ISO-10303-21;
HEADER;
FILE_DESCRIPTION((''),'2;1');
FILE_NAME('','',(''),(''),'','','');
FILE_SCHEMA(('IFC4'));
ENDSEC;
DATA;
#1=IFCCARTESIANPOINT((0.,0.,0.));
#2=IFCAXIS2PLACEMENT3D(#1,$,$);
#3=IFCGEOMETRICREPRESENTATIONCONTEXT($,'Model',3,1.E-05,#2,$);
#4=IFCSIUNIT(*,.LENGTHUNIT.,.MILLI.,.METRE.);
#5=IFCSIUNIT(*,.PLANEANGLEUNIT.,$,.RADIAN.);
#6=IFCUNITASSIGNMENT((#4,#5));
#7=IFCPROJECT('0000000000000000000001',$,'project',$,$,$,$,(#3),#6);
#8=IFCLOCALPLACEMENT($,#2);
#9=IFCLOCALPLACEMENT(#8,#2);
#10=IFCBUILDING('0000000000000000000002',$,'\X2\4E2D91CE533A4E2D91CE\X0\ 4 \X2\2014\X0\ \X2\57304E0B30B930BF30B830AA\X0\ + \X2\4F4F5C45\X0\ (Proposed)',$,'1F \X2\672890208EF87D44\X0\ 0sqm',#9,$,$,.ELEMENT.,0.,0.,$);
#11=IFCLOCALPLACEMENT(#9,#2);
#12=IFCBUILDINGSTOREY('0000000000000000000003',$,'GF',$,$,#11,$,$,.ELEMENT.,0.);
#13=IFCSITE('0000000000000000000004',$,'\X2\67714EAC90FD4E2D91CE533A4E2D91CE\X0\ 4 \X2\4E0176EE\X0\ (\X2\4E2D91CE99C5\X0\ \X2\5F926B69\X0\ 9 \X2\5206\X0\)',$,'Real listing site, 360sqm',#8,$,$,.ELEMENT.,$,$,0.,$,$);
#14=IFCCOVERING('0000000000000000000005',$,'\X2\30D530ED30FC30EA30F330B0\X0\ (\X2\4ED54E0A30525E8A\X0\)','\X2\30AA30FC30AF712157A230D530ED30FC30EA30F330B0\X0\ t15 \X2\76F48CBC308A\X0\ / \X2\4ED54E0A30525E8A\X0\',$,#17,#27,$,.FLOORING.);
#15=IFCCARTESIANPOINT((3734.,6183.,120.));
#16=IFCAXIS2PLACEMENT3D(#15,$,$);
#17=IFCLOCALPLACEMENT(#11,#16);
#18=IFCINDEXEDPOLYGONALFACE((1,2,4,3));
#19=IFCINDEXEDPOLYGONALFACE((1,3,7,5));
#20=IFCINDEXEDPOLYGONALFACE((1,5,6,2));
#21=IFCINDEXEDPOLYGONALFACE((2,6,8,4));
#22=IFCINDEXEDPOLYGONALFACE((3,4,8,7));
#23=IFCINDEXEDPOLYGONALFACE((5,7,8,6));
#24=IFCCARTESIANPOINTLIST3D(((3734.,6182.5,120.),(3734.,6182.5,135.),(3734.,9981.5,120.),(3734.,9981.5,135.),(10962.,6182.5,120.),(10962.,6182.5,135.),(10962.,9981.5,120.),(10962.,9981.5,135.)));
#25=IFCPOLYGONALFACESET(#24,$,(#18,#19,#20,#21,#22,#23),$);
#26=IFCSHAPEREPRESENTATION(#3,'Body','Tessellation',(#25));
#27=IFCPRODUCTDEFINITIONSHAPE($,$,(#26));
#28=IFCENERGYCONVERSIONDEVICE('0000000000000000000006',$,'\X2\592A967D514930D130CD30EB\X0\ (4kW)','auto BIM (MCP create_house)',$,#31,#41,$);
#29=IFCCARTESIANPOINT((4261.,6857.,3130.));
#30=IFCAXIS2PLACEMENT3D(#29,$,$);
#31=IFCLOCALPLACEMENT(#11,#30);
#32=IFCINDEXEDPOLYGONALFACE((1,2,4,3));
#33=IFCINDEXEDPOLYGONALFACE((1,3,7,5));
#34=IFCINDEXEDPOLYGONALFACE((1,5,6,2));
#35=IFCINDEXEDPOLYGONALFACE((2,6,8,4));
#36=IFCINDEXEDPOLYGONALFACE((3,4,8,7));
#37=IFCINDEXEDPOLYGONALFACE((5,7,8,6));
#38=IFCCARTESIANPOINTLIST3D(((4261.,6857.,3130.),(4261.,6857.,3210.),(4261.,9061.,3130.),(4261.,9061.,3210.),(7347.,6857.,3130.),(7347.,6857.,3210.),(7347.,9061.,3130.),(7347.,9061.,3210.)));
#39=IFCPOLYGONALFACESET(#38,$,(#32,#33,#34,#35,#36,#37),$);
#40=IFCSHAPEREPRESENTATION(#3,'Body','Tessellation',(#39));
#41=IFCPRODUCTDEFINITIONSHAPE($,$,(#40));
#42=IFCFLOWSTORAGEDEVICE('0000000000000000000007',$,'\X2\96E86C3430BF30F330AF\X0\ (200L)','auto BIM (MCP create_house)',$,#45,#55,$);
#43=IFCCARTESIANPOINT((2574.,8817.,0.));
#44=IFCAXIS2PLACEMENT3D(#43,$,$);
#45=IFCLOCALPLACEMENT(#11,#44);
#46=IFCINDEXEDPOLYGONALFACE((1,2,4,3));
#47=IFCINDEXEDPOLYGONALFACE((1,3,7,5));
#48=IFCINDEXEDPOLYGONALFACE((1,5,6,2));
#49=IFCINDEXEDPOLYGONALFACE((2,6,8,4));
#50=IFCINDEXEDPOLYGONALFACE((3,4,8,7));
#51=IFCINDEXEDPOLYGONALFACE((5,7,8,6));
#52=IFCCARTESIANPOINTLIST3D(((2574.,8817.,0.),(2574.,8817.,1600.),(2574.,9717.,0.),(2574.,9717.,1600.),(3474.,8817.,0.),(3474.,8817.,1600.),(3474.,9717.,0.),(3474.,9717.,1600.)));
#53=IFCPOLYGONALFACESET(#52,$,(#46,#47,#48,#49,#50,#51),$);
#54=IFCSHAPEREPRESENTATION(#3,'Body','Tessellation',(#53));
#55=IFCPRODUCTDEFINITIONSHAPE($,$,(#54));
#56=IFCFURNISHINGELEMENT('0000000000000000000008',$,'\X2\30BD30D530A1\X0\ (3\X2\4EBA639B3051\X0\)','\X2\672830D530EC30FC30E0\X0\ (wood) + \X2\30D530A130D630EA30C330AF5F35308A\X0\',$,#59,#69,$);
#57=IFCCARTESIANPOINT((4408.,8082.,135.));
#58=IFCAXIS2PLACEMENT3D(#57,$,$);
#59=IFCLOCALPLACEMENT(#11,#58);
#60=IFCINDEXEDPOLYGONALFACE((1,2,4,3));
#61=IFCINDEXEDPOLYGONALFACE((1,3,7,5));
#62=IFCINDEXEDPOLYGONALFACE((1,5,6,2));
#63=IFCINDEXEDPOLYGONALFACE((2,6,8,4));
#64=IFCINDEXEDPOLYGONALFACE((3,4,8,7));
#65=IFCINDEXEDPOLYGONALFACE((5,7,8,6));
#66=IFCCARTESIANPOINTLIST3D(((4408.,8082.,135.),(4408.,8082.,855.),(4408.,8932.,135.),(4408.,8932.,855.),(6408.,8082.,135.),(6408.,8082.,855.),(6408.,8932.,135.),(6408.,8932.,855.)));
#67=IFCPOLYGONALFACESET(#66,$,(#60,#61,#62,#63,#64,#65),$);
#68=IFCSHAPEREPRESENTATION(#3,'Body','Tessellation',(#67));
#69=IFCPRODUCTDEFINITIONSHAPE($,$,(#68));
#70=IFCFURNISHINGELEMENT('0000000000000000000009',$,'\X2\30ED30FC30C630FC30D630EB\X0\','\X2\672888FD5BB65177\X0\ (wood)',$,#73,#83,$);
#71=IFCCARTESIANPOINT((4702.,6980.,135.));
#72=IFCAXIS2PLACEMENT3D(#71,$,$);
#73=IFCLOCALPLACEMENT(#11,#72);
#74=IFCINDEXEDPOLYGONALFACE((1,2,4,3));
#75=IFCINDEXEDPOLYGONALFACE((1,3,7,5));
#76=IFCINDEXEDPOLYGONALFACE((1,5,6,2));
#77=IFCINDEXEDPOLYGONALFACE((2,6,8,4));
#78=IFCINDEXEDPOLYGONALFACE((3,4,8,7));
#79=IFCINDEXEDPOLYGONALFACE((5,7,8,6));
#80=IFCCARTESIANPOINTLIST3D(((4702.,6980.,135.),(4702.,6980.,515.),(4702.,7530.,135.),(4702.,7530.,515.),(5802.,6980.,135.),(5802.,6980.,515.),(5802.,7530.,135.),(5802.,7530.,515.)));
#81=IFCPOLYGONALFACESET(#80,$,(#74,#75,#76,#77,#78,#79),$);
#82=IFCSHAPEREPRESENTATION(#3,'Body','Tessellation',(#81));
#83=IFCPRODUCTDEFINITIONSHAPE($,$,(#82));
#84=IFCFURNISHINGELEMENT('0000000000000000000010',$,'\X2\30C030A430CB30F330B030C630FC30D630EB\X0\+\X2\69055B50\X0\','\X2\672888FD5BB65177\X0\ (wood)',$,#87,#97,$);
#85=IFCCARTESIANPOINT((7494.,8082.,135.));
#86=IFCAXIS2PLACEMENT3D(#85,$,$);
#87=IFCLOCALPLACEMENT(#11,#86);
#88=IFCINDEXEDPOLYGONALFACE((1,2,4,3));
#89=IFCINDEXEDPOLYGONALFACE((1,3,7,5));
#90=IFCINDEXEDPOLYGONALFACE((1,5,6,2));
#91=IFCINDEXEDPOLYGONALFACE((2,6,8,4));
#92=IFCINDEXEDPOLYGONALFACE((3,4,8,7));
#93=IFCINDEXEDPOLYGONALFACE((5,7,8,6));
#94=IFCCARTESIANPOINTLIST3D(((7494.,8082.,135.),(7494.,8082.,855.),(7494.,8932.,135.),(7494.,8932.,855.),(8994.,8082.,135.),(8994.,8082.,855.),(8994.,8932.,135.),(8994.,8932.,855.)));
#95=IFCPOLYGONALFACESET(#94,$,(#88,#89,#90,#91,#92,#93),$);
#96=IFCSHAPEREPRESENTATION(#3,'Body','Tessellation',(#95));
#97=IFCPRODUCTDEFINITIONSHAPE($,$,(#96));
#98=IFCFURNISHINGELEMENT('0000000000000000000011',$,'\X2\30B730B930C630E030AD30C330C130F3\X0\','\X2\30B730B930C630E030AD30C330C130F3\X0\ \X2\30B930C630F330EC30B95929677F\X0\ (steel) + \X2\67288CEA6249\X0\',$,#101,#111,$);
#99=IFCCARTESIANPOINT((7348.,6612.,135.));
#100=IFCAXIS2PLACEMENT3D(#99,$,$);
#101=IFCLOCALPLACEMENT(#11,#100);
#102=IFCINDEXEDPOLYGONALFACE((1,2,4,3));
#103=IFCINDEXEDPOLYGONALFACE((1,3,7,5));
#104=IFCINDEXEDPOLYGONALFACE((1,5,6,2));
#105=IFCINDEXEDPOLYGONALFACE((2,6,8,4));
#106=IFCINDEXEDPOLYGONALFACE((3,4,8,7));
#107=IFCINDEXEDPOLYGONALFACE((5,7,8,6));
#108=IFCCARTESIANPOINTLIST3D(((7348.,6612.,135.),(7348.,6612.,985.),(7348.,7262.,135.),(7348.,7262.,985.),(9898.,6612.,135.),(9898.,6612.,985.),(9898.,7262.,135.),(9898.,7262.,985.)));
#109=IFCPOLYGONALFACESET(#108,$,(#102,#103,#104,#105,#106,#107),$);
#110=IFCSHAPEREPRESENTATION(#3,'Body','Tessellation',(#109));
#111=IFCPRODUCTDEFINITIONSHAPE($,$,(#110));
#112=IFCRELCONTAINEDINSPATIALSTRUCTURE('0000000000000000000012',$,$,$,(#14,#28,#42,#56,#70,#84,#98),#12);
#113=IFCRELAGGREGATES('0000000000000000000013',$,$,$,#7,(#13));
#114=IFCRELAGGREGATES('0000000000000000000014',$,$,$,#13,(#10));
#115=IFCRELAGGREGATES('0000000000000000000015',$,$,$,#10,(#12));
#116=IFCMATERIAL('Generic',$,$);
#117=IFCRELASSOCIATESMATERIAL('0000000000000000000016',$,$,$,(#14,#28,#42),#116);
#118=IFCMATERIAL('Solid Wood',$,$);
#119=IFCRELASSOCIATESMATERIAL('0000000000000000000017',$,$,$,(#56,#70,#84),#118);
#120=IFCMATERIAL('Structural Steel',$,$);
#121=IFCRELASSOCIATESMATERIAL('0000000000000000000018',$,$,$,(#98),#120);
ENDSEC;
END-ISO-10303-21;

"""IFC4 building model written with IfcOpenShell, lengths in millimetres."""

from ifc_helpers import new_model, si_unit, frame, frame_2d, origin, place, context, project, spatial, rectangle, extrude, material, element, save


model = new_model("IFC4")

# Units and contexts
model_context = context("Model", 3, precision=1e-05, world=origin())
ifc_project = project(units=[si_unit("LENGTHUNIT", "METRE", prefix="MILLI"), si_unit("PLANEANGLEUNIT", "RADIAN")], contexts=[model_context])

# Site, building, storey
site_placement = place(None, origin())
site = spatial("IfcSite", under=ifc_project, at=site_placement, Name="東京都中野区中野 4 丁目 (中野駅 徒歩 9 分)", ObjectType="Real listing site, 360sqm", CompositionType="ELEMENT", RefElevation=0.0)
building_placement = place(site_placement, origin())
building = spatial("IfcBuilding", under=site, at=building_placement, Name="中野区中野 4 — 地下スタジオ + 住居 (Proposed)", ObjectType="1F 木造軸組 0sqm", CompositionType="ELEMENT", ElevationOfRefHeight=0.0, ElevationOfTerrain=0.0)
storey_placement = place(building_placement, origin())
storey = spatial("IfcBuildingStorey", under=building, at=storey_placement, Name="GF", CompositionType="ELEMENT", Elevation=0.0)

# Shared definitions
ifc_material_1 = material(Name="Solid Wood")

# Shared definitions
ifc_material_2 = material(Name="Structural Steel")

# Covering
ifc_material_3 = material(Name="Generic")
covering_placement = place(storey_placement, frame((3734.0, 6183.0, 120.0)))
element("IfcCovering", 1, at=covering_placement, inside=storey, material=ifc_material_3, Name="フローリング (仕上げ床)", Description="オーク無垢フローリング t15 直貼り / 仕上げ床", PredefinedType="FLOORING", context=model_context, shape_type="SweptSolid", body=[
    extrude(rectangle(XDim=7228.0, YDim=3799.0, at=frame_2d((3614.0, 1899.0))), frame((3734.0, 6183.0, 120.0)), (0.0, 0.0, 1.0), 15.0),
])

# Energy conversion device
energy_conversion_device_placement = place(storey_placement, frame((4261.0, 6857.0, 3130.0)))
element("IfcEnergyConversionDevice", 2, at=energy_conversion_device_placement, inside=storey, material=ifc_material_3, Name="太陽光パネル (4kW)", Description="auto BIM (MCP create_house)", context=model_context, shape_type="SweptSolid", body=[
    extrude(rectangle(XDim=3086.0, YDim=2204.0, at=frame_2d((1543.0, 1102.0))), frame((4261.0, 6857.0, 3130.0)), (0.0, 0.0, 1.0), 80.0),
])

# Flow storage device
flow_storage_device_placement = place(storey_placement, frame((2574.0, 8817.0, 0.0)))
element("IfcFlowStorageDevice", 3, at=flow_storage_device_placement, inside=storey, material=ifc_material_3, Name="雨水タンク (200L)", Description="auto BIM (MCP create_house)", context=model_context, shape_type="SweptSolid", body=[
    extrude(rectangle(XDim=900.0, YDim=900.0, at=frame_2d((450.0, 450.0))), frame((2574.0, 8817.0, 0.0)), (0.0, 0.0, 1.0), 1600.0),
])

# Furnishing elements
furnishing_1_placement = place(storey_placement, frame((4408.0, 8082.0, 135.0)))
element("IfcFurnishingElement", 4, at=furnishing_1_placement, inside=storey, material=ifc_material_1, Name="ソファ (3人掛け)", Description="木フレーム (wood) + ファブリック張り", context=model_context, shape_type="SweptSolid", body=[
    extrude(rectangle(XDim=2000.0, YDim=850.0, at=frame_2d((1000.0, 425.0))), frame((4408.0, 8082.0, 135.0)), (0.0, 0.0, 1.0), 720.0),
])
furnishing_2_placement = place(storey_placement, frame((4702.0, 6980.0, 135.0)))
element("IfcFurnishingElement", 5, at=furnishing_2_placement, inside=storey, material=ifc_material_1, Name="ローテーブル", Description="木製家具 (wood)", context=model_context, shape_type="SweptSolid", body=[
    extrude(rectangle(XDim=1100.0, YDim=550.0, at=frame_2d((550.0, 275.0))), frame((4702.0, 6980.0, 135.0)), (0.0, 0.0, 1.0), 380.0),
])
furnishing_3_placement = place(storey_placement, frame((7494.0, 8082.0, 135.0)))
element("IfcFurnishingElement", 6, at=furnishing_3_placement, inside=storey, material=ifc_material_1, Name="ダイニングテーブル+椅子", Description="木製家具 (wood)", context=model_context, shape_type="SweptSolid", body=[
    extrude(rectangle(XDim=1500.0, YDim=850.0, at=frame_2d((750.0, 425.0))), frame((7494.0, 8082.0, 135.0)), (0.0, 0.0, 1.0), 720.0),
])
furnishing_4_placement = place(storey_placement, frame((7348.0, 6612.0, 135.0)))
element("IfcFurnishingElement", 7, at=furnishing_4_placement, inside=storey, material=ifc_material_2, Name="システムキッチン", Description="システムキッチン ステンレス天板 (steel) + 木質扉", context=model_context, shape_type="SweptSolid", body=[
    extrude(rectangle(XDim=2550.0, YDim=650.0, at=frame_2d((1275.0, 325.0))), frame((7348.0, 6612.0, 135.0)), (0.0, 0.0, 1.0), 850.0),
])

save(model, "model.ifc")
